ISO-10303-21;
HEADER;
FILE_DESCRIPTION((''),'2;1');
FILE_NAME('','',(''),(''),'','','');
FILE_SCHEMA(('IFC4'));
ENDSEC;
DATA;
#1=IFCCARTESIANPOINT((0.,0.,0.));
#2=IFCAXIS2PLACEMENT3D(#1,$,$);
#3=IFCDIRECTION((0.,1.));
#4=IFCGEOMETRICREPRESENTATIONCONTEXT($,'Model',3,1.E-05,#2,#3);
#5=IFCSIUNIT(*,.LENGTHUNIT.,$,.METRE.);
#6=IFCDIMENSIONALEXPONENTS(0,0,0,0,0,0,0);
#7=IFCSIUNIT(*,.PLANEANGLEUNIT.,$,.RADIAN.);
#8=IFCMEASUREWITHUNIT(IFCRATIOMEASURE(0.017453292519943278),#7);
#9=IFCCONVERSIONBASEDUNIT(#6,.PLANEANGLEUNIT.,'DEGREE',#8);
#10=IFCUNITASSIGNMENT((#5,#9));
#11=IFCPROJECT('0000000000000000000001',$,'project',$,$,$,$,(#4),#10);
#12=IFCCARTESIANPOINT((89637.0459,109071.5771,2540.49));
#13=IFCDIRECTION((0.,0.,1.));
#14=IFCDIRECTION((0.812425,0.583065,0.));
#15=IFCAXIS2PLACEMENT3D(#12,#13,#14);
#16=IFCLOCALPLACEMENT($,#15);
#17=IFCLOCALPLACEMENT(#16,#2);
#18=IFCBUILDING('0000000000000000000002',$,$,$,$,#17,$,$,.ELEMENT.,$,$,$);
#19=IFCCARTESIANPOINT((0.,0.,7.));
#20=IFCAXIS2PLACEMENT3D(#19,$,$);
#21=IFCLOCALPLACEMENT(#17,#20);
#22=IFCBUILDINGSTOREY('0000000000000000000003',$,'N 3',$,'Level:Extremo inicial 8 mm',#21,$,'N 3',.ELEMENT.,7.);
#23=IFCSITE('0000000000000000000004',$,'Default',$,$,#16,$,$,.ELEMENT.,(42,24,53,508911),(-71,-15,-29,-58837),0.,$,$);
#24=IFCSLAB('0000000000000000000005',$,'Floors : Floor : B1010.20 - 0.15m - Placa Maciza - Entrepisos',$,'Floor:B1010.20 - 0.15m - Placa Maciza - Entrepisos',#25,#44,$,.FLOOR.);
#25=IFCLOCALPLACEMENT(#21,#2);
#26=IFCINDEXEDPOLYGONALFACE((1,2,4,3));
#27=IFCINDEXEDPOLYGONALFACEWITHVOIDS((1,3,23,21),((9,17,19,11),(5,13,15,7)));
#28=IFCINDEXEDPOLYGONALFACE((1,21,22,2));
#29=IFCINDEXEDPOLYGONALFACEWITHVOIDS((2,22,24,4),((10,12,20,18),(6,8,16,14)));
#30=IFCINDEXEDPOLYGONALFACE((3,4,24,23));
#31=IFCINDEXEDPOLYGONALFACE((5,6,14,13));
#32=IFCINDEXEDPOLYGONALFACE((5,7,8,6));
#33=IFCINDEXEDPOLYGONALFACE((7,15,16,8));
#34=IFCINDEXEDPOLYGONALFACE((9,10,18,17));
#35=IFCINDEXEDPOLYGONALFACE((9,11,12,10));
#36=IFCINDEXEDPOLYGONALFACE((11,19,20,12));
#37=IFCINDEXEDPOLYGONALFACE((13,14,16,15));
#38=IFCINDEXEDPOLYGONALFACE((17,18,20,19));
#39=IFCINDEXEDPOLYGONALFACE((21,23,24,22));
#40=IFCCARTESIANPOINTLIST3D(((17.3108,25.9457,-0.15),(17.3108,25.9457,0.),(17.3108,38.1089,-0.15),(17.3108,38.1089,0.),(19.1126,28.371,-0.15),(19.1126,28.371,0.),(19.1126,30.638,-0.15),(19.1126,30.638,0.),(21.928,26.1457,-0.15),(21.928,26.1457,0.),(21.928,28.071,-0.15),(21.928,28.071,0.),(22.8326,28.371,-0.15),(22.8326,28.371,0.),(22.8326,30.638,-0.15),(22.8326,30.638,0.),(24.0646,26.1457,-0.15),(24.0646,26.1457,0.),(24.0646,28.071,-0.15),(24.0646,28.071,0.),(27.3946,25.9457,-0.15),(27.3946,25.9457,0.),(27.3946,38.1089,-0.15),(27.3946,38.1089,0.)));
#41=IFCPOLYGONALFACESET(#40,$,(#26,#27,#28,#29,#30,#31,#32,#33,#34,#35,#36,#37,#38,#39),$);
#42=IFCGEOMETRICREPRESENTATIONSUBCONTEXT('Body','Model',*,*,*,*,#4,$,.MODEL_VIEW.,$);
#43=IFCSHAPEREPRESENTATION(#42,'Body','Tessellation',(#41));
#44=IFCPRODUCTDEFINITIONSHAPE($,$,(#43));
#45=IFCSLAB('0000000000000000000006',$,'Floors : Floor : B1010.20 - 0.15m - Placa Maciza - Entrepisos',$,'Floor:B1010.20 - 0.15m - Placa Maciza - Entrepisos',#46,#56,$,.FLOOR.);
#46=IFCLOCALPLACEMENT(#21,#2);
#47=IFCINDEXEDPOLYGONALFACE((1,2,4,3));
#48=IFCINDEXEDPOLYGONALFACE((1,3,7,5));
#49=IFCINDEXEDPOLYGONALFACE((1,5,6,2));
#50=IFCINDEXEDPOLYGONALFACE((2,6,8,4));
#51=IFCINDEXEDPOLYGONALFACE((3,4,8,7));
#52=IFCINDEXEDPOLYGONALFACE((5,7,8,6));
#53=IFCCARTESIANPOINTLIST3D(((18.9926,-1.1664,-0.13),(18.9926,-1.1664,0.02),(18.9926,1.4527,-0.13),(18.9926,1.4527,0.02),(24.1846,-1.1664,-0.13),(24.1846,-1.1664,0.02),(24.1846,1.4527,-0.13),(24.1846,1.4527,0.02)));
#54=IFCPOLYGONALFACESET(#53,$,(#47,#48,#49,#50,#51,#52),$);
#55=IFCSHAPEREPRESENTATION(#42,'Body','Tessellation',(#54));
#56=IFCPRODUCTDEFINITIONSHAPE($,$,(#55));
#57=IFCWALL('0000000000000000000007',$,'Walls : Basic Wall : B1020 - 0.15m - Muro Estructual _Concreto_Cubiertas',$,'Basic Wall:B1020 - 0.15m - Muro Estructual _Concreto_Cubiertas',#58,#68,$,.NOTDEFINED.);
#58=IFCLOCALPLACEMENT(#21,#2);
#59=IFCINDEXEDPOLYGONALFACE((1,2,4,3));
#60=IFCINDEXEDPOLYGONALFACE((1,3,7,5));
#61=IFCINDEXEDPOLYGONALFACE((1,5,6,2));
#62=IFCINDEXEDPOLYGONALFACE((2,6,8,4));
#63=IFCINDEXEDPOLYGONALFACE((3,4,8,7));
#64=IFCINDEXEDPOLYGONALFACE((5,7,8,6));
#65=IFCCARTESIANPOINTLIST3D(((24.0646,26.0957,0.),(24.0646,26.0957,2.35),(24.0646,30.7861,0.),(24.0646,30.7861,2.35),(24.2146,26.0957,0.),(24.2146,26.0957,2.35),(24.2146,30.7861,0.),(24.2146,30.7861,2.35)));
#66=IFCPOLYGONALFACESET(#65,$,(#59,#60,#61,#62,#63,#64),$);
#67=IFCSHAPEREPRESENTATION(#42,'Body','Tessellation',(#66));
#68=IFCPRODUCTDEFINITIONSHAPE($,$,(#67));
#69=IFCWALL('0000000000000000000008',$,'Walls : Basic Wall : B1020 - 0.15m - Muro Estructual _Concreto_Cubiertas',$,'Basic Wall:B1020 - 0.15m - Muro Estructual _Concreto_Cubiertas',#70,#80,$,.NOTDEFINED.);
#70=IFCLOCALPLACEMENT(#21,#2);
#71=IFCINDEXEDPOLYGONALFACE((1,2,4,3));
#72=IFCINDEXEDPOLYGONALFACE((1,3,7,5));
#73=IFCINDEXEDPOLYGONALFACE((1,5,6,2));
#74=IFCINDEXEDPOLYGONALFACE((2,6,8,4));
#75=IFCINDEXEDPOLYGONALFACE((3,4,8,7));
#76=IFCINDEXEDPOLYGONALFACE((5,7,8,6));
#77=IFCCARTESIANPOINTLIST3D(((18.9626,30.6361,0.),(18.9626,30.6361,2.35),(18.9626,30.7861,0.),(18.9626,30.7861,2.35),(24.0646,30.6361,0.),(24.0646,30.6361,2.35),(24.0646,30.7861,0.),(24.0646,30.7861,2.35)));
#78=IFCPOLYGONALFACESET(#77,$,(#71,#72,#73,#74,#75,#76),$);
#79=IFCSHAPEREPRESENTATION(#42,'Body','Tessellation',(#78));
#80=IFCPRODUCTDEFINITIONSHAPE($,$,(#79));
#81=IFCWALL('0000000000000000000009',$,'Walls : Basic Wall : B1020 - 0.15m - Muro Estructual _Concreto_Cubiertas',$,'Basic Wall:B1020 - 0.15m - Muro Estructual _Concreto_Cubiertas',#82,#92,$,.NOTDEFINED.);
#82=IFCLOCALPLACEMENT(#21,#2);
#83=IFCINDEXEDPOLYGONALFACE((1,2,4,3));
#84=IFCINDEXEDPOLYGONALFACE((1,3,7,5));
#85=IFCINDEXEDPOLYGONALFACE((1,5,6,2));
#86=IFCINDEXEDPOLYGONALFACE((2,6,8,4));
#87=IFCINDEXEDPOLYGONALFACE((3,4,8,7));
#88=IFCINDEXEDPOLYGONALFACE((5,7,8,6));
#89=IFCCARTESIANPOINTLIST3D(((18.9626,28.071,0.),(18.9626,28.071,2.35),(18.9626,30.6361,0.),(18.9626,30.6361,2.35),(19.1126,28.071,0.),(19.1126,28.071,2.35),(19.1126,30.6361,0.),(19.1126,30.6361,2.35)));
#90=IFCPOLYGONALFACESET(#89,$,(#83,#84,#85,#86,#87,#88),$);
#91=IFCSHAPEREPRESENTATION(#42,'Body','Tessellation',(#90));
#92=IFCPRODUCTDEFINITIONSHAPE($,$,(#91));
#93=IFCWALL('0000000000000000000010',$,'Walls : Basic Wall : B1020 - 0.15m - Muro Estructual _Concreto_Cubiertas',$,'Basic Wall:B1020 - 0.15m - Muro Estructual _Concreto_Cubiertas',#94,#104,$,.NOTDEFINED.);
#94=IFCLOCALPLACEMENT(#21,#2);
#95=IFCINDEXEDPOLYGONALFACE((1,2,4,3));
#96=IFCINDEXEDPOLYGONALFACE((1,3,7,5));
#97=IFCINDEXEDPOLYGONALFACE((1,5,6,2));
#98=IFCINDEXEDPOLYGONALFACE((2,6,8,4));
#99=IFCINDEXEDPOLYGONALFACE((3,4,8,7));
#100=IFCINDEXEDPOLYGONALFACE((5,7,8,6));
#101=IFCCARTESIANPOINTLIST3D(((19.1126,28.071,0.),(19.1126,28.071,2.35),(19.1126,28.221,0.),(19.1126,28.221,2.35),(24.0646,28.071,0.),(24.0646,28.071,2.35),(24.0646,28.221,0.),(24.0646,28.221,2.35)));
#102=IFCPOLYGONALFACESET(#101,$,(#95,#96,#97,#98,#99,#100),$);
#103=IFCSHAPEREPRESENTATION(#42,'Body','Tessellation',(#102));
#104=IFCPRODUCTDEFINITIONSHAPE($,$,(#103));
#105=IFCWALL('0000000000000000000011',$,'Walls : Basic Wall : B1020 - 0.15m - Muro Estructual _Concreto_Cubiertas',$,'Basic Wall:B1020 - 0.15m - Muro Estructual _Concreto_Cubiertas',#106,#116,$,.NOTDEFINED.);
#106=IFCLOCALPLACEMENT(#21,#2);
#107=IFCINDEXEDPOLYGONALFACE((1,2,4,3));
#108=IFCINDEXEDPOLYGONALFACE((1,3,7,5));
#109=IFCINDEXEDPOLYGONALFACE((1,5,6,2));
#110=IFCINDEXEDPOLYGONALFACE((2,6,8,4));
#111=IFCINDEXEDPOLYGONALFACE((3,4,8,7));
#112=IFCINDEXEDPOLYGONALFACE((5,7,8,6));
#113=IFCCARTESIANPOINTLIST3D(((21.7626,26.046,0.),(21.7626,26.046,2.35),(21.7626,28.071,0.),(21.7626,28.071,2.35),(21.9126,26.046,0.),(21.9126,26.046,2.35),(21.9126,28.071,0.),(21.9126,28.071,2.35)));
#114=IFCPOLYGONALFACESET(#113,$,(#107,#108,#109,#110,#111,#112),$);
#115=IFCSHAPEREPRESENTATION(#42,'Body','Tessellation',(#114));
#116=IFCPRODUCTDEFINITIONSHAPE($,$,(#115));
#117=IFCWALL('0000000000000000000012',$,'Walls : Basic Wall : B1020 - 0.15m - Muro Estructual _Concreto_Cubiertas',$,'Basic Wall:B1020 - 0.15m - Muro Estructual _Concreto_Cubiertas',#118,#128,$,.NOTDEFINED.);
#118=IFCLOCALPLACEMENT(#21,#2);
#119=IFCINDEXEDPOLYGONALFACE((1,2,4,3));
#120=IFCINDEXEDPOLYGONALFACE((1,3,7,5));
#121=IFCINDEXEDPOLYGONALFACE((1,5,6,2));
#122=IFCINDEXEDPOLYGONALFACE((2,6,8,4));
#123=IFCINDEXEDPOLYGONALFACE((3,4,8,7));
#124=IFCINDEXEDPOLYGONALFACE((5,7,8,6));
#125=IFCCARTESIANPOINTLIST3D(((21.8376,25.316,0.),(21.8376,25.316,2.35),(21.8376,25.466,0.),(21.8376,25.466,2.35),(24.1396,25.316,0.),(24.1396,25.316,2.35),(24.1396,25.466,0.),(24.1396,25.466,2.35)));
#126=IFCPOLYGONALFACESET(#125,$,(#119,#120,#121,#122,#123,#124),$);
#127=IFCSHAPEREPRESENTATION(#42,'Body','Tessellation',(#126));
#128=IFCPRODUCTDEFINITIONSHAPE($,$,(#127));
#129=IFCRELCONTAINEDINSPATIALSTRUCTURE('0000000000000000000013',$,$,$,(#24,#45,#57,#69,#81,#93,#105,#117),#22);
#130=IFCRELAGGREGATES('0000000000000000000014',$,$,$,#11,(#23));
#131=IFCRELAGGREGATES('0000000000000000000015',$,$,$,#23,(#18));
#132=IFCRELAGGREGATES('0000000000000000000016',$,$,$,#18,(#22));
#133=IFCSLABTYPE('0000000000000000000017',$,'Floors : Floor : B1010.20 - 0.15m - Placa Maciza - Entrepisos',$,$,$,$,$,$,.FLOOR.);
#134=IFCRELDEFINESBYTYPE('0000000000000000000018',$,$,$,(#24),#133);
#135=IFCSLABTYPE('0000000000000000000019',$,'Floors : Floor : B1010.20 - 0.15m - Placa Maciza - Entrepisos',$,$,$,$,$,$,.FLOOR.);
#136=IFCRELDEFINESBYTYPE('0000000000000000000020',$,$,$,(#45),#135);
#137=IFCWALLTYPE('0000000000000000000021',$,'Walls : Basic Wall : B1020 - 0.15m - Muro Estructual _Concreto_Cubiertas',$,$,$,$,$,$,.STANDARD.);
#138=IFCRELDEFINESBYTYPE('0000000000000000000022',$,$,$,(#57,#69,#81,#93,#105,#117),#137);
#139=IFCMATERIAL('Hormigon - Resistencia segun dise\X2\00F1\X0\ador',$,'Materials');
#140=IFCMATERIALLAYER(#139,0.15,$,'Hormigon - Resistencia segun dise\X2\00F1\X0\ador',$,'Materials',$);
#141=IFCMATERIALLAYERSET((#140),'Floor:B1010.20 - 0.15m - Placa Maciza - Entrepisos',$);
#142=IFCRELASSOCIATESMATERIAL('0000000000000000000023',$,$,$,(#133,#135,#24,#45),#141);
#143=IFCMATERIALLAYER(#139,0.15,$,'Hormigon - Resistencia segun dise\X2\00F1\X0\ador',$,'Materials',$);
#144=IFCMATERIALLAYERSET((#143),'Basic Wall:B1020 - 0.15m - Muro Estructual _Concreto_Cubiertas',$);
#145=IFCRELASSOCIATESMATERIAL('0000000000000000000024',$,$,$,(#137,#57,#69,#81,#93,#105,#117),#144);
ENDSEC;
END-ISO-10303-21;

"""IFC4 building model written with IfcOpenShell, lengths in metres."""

from ifc_helpers import new_model, entity, si_unit, converted_unit, direction, frame, frame_2d, origin, origin_2d_with_axis, place, context, subcontext, project, spatial, rectangle, extrude, material, layer, layer_set, layer_usage, type_object, element, save


model = new_model("IFC4")

# Units and contexts
model_context = context("Model", 3, precision=1e-05, world=origin(), true_north=direction((0.0, 1.0)))
body_context = subcontext(model_context, "Body", "Model", "MODEL_VIEW")
ifc_project = project(units=[si_unit("LENGTHUNIT", "METRE"), converted_unit("PLANEANGLEUNIT", "DEGREE", entity("IfcRatioMeasure", 0.017453292519943278), si_unit("PLANEANGLEUNIT", "RADIAN"), dimensions=[0, 0, 0, 0, 0, 0, 0])], contexts=[model_context])

# Site, building, storey
site_placement = place(None, frame((89637.0459, 109071.5771, 2540.49), z_axis=(0.0, 0.0, 1.0), x_axis=(0.812425, 0.583065, 0.0)))
site = spatial("IfcSite", under=ifc_project, at=site_placement, Name="Default", CompositionType="ELEMENT", RefLatitude=(42, 24, 53, 508911), RefLongitude=(-71, -15, -29, -58837), RefElevation=0.0)
building_placement = place(site_placement, origin())
building = spatial("IfcBuilding", under=site, at=building_placement, CompositionType="ELEMENT")
storey_placement = place(building_placement, frame((0.0, 0.0, 7.0)))
storey = spatial("IfcBuildingStorey", under=building, at=storey_placement, Name="N 3", ObjectType="Level:Extremo inicial 8 mm", LongName="N 3", CompositionType="ELEMENT", Elevation=7.0)

# Slab, openings
ifc_material_1 = material(Name="Hormigon - Resistencia segun diseñador", Category="Materials")
ifc_layer_1 = layer(ifc_material_1, 0.15, Name="Hormigon - Resistencia segun diseñador", Category="Materials")
ifc_layer_set_1 = layer_set([ifc_layer_1], Name="Floor:B1010.20 - 0.15m - Placa Maciza - Entrepisos")
ifc_layer_usage_1 = layer_usage(ifc_layer_set_1, "AXIS3", "POSITIVE", 0.0)
slab_type_1 = type_object("IfcSlabType", Name="Floors : Floor : B1010.20 - 0.15m - Placa Maciza - Entrepisos", PredefinedType="FLOOR", material=ifc_layer_set_1)
slab_1_placement = place(storey_placement, frame((17.3108, 25.9457, -0.15)))
slab_1 = element("IfcSlab", 1, at=slab_1_placement, inside=storey, type_object=slab_type_1, material=ifc_layer_usage_1, Name="Floors : Floor : B1010.20 - 0.15m - Placa Maciza - Entrepisos", ObjectType="Floor:B1010.20 - 0.15m - Placa Maciza - Entrepisos", PredefinedType="FLOOR", context=body_context, shape_type="SweptSolid", body=[
    extrude(rectangle(XDim=12.1632, YDim=10.0838, at=frame_2d((0.0, 0.0), x_axis=(0.0, 1.0))), frame((5.0419, 6.0816, 0.15), z_axis=(0.0, 0.0, -1.0), x_axis=(-1.0, 0.0, 0.0)), (0.0, 0.0, 1.0), 0.15),
])
opening_1_placement = place(slab_1_placement, frame((3.6617, 3.5588, 0.15)))
element("IfcOpeningElement", 2, at=opening_1_placement, cuts=slab_1, ObjectType="Opening", context=body_context, shape_type="SweptSolid", body=[
    extrude(rectangle(XDim=2.2671, YDim=3.72, at=origin_2d_with_axis()), frame((0.0, 0.0, 0.0), z_axis=(0.0, 0.0, 1.0), x_axis=(0.0, -1.0, 0.0)), (0.0, 0.0, -1.0), 0.15),
])
opening_2_placement = place(slab_1_placement, frame((5.6855, 1.1626, 0.15)))
element("IfcOpeningElement", 3, at=opening_2_placement, cuts=slab_1, ObjectType="Opening", context=body_context, shape_type="SweptSolid", body=[
    extrude(rectangle(XDim=1.9253, YDim=2.1366, at=origin_2d_with_axis()), frame((0.0, 0.0, 0.0), z_axis=(0.0, 0.0, -1.0), x_axis=(0.0, -1.0, 0.0)), (0.0, 0.0, 1.0), 0.15),
])

# Slab
ifc_layer_usage_2 = layer_usage(ifc_layer_set_1, "AXIS3", "POSITIVE", 0.0)
slab_type_2 = type_object("IfcSlabType", Name="Floors : Floor : B1010.20 - 0.15m - Placa Maciza - Entrepisos", PredefinedType="FLOOR", material=ifc_layer_set_1)
slab_2_placement = place(storey_placement, origin())
element("IfcSlab", 4, at=slab_2_placement, inside=storey, type_object=slab_type_2, material=ifc_layer_usage_2, Name="Floors : Floor : B1010.20 - 0.15m - Placa Maciza - Entrepisos", ObjectType="Floor:B1010.20 - 0.15m - Placa Maciza - Entrepisos", PredefinedType="FLOOR", context=body_context, shape_type="SweptSolid", body=[
    extrude(rectangle(XDim=2.6191, YDim=5.1921, at=frame_2d((0.0, 0.0), x_axis=(1.0, 0.0))), frame((21.5886, 0.1431, 0.02), z_axis=(0.0, 0.0, -1.0), x_axis=(0.0, 1.0, 0.0)), (0.0, 0.0, 1.0), 0.15),
])

# Walls
ifc_layer_2 = layer(ifc_material_1, 0.15, Name="Hormigon - Resistencia segun diseñador", Category="Materials")
ifc_layer_set_2 = layer_set([ifc_layer_2], Name="Basic Wall:B1020 - 0.15m - Muro Estructual _Concreto_Cubiertas")
ifc_layer_usage_3 = layer_usage(ifc_layer_set_2, "AXIS2", "NEGATIVE", 0.075)
wall_type = type_object("IfcWallType", Name="Walls : Basic Wall : B1020 - 0.15m - Muro Estructual _Concreto_Cubiertas", PredefinedType="STANDARD", material=ifc_layer_set_2)
wall_1_placement = place(storey_placement, frame((24.1396, 30.7861, 0.0), z_axis=(0.0, 0.0, 1.0), x_axis=(0.0, -1.0, 0.0)))
element("IfcWall", 5, at=wall_1_placement, inside=storey, type_object=wall_type, material=ifc_layer_usage_3, Name="Walls : Basic Wall : B1020 - 0.15m - Muro Estructual _Concreto_Cubiertas", ObjectType="Basic Wall:B1020 - 0.15m - Muro Estructual _Concreto_Cubiertas", PredefinedType="NOTDEFINED", context=body_context, shape_type="SweptSolid", body=[
    extrude(rectangle(XDim=4.6904, YDim=0.15, at=frame_2d((2.3452, 0.0), x_axis=(-1.0, 0.0))), origin(), (0.0, 0.0, 1.0), 2.35),
])
ifc_layer_usage_4 = layer_usage(ifc_layer_set_2, "AXIS2", "NEGATIVE", 0.075)
wall_2_placement = place(storey_placement, frame((24.0646, 30.7111, 0.0), z_axis=(0.0, 0.0, 1.0), x_axis=(-1.0, 0.0, 0.0)))
element("IfcWall", 6, at=wall_2_placement, inside=storey, type_object=wall_type, material=ifc_layer_usage_4, Name="Walls : Basic Wall : B1020 - 0.15m - Muro Estructual _Concreto_Cubiertas", ObjectType="Basic Wall:B1020 - 0.15m - Muro Estructual _Concreto_Cubiertas", PredefinedType="NOTDEFINED", context=body_context, shape_type="SweptSolid", body=[
    extrude(rectangle(XDim=5.1021, YDim=0.15, at=frame_2d((2.551, 0.0), x_axis=(-1.0, 0.0))), origin(), (0.0, 0.0, 1.0), 2.35),
])
ifc_layer_usage_5 = layer_usage(ifc_layer_set_2, "AXIS2", "NEGATIVE", 0.075)
wall_3_placement = place(storey_placement, frame((19.0376, 30.6361, 0.0), z_axis=(0.0, 0.0, 1.0), x_axis=(0.0, -1.0, 0.0)))
element("IfcWall", 7, at=wall_3_placement, inside=storey, type_object=wall_type, material=ifc_layer_usage_5, Name="Walls : Basic Wall : B1020 - 0.15m - Muro Estructual _Concreto_Cubiertas", ObjectType="Basic Wall:B1020 - 0.15m - Muro Estructual _Concreto_Cubiertas", PredefinedType="NOTDEFINED", context=body_context, shape_type="SweptSolid", body=[
    extrude(rectangle(XDim=2.5651, YDim=0.15, at=frame_2d((1.2825, 0.0), x_axis=(-1.0, 0.0))), origin(), (0.0, 0.0, 1.0), 2.35),
])
ifc_layer_usage_6 = layer_usage(ifc_layer_set_2, "AXIS2", "NEGATIVE", 0.075)
wall_4_placement = place(storey_placement, frame((19.1126, 28.146, 0.0)))
element("IfcWall", 8, at=wall_4_placement, inside=storey, type_object=wall_type, material=ifc_layer_usage_6, Name="Walls : Basic Wall : B1020 - 0.15m - Muro Estructual _Concreto_Cubiertas", ObjectType="Basic Wall:B1020 - 0.15m - Muro Estructual _Concreto_Cubiertas", PredefinedType="NOTDEFINED", context=body_context, shape_type="SweptSolid", body=[
    extrude(rectangle(XDim=4.9521, YDim=0.15, at=frame_2d((2.476, 0.0), x_axis=(-1.0, 0.0))), origin(), (0.0, 0.0, 1.0), 2.35),
])
ifc_layer_usage_7 = layer_usage(ifc_layer_set_2, "AXIS2", "NEGATIVE", 0.075)
wall_5_placement = place(storey_placement, frame((21.8376, 28.071, 0.0), z_axis=(0.0, 0.0, 1.0), x_axis=(0.0, -1.0, 0.0)))
element("IfcWall", 9, at=wall_5_placement, inside=storey, type_object=wall_type, material=ifc_layer_usage_7, Name="Walls : Basic Wall : B1020 - 0.15m - Muro Estructual _Concreto_Cubiertas", ObjectType="Basic Wall:B1020 - 0.15m - Muro Estructual _Concreto_Cubiertas", PredefinedType="NOTDEFINED", context=body_context, shape_type="SweptSolid", body=[
    extrude(rectangle(XDim=2.025, YDim=0.15, at=frame_2d((1.0125, 0.0), x_axis=(-1.0, 0.0))), origin(), (0.0, 0.0, 1.0), 2.35),
])
ifc_layer_usage_8 = layer_usage(ifc_layer_set_2, "AXIS2", "NEGATIVE", 0.075)
wall_6_placement = place(storey_placement, frame((21.8376, 25.391, 0.0)))
element("IfcWall", 10, at=wall_6_placement, inside=storey, type_object=wall_type, material=ifc_layer_usage_8, Name="Walls : Basic Wall : B1020 - 0.15m - Muro Estructual _Concreto_Cubiertas", ObjectType="Basic Wall:B1020 - 0.15m - Muro Estructual _Concreto_Cubiertas", PredefinedType="NOTDEFINED", context=body_context, shape_type="SweptSolid", body=[
    extrude(rectangle(XDim=2.3021, YDim=0.15, at=frame_2d((1.151, 0.0), x_axis=(-1.0, 0.0))), origin(), (0.0, 0.0, 1.0), 2.35),
])

save(model, "model.ifc")
